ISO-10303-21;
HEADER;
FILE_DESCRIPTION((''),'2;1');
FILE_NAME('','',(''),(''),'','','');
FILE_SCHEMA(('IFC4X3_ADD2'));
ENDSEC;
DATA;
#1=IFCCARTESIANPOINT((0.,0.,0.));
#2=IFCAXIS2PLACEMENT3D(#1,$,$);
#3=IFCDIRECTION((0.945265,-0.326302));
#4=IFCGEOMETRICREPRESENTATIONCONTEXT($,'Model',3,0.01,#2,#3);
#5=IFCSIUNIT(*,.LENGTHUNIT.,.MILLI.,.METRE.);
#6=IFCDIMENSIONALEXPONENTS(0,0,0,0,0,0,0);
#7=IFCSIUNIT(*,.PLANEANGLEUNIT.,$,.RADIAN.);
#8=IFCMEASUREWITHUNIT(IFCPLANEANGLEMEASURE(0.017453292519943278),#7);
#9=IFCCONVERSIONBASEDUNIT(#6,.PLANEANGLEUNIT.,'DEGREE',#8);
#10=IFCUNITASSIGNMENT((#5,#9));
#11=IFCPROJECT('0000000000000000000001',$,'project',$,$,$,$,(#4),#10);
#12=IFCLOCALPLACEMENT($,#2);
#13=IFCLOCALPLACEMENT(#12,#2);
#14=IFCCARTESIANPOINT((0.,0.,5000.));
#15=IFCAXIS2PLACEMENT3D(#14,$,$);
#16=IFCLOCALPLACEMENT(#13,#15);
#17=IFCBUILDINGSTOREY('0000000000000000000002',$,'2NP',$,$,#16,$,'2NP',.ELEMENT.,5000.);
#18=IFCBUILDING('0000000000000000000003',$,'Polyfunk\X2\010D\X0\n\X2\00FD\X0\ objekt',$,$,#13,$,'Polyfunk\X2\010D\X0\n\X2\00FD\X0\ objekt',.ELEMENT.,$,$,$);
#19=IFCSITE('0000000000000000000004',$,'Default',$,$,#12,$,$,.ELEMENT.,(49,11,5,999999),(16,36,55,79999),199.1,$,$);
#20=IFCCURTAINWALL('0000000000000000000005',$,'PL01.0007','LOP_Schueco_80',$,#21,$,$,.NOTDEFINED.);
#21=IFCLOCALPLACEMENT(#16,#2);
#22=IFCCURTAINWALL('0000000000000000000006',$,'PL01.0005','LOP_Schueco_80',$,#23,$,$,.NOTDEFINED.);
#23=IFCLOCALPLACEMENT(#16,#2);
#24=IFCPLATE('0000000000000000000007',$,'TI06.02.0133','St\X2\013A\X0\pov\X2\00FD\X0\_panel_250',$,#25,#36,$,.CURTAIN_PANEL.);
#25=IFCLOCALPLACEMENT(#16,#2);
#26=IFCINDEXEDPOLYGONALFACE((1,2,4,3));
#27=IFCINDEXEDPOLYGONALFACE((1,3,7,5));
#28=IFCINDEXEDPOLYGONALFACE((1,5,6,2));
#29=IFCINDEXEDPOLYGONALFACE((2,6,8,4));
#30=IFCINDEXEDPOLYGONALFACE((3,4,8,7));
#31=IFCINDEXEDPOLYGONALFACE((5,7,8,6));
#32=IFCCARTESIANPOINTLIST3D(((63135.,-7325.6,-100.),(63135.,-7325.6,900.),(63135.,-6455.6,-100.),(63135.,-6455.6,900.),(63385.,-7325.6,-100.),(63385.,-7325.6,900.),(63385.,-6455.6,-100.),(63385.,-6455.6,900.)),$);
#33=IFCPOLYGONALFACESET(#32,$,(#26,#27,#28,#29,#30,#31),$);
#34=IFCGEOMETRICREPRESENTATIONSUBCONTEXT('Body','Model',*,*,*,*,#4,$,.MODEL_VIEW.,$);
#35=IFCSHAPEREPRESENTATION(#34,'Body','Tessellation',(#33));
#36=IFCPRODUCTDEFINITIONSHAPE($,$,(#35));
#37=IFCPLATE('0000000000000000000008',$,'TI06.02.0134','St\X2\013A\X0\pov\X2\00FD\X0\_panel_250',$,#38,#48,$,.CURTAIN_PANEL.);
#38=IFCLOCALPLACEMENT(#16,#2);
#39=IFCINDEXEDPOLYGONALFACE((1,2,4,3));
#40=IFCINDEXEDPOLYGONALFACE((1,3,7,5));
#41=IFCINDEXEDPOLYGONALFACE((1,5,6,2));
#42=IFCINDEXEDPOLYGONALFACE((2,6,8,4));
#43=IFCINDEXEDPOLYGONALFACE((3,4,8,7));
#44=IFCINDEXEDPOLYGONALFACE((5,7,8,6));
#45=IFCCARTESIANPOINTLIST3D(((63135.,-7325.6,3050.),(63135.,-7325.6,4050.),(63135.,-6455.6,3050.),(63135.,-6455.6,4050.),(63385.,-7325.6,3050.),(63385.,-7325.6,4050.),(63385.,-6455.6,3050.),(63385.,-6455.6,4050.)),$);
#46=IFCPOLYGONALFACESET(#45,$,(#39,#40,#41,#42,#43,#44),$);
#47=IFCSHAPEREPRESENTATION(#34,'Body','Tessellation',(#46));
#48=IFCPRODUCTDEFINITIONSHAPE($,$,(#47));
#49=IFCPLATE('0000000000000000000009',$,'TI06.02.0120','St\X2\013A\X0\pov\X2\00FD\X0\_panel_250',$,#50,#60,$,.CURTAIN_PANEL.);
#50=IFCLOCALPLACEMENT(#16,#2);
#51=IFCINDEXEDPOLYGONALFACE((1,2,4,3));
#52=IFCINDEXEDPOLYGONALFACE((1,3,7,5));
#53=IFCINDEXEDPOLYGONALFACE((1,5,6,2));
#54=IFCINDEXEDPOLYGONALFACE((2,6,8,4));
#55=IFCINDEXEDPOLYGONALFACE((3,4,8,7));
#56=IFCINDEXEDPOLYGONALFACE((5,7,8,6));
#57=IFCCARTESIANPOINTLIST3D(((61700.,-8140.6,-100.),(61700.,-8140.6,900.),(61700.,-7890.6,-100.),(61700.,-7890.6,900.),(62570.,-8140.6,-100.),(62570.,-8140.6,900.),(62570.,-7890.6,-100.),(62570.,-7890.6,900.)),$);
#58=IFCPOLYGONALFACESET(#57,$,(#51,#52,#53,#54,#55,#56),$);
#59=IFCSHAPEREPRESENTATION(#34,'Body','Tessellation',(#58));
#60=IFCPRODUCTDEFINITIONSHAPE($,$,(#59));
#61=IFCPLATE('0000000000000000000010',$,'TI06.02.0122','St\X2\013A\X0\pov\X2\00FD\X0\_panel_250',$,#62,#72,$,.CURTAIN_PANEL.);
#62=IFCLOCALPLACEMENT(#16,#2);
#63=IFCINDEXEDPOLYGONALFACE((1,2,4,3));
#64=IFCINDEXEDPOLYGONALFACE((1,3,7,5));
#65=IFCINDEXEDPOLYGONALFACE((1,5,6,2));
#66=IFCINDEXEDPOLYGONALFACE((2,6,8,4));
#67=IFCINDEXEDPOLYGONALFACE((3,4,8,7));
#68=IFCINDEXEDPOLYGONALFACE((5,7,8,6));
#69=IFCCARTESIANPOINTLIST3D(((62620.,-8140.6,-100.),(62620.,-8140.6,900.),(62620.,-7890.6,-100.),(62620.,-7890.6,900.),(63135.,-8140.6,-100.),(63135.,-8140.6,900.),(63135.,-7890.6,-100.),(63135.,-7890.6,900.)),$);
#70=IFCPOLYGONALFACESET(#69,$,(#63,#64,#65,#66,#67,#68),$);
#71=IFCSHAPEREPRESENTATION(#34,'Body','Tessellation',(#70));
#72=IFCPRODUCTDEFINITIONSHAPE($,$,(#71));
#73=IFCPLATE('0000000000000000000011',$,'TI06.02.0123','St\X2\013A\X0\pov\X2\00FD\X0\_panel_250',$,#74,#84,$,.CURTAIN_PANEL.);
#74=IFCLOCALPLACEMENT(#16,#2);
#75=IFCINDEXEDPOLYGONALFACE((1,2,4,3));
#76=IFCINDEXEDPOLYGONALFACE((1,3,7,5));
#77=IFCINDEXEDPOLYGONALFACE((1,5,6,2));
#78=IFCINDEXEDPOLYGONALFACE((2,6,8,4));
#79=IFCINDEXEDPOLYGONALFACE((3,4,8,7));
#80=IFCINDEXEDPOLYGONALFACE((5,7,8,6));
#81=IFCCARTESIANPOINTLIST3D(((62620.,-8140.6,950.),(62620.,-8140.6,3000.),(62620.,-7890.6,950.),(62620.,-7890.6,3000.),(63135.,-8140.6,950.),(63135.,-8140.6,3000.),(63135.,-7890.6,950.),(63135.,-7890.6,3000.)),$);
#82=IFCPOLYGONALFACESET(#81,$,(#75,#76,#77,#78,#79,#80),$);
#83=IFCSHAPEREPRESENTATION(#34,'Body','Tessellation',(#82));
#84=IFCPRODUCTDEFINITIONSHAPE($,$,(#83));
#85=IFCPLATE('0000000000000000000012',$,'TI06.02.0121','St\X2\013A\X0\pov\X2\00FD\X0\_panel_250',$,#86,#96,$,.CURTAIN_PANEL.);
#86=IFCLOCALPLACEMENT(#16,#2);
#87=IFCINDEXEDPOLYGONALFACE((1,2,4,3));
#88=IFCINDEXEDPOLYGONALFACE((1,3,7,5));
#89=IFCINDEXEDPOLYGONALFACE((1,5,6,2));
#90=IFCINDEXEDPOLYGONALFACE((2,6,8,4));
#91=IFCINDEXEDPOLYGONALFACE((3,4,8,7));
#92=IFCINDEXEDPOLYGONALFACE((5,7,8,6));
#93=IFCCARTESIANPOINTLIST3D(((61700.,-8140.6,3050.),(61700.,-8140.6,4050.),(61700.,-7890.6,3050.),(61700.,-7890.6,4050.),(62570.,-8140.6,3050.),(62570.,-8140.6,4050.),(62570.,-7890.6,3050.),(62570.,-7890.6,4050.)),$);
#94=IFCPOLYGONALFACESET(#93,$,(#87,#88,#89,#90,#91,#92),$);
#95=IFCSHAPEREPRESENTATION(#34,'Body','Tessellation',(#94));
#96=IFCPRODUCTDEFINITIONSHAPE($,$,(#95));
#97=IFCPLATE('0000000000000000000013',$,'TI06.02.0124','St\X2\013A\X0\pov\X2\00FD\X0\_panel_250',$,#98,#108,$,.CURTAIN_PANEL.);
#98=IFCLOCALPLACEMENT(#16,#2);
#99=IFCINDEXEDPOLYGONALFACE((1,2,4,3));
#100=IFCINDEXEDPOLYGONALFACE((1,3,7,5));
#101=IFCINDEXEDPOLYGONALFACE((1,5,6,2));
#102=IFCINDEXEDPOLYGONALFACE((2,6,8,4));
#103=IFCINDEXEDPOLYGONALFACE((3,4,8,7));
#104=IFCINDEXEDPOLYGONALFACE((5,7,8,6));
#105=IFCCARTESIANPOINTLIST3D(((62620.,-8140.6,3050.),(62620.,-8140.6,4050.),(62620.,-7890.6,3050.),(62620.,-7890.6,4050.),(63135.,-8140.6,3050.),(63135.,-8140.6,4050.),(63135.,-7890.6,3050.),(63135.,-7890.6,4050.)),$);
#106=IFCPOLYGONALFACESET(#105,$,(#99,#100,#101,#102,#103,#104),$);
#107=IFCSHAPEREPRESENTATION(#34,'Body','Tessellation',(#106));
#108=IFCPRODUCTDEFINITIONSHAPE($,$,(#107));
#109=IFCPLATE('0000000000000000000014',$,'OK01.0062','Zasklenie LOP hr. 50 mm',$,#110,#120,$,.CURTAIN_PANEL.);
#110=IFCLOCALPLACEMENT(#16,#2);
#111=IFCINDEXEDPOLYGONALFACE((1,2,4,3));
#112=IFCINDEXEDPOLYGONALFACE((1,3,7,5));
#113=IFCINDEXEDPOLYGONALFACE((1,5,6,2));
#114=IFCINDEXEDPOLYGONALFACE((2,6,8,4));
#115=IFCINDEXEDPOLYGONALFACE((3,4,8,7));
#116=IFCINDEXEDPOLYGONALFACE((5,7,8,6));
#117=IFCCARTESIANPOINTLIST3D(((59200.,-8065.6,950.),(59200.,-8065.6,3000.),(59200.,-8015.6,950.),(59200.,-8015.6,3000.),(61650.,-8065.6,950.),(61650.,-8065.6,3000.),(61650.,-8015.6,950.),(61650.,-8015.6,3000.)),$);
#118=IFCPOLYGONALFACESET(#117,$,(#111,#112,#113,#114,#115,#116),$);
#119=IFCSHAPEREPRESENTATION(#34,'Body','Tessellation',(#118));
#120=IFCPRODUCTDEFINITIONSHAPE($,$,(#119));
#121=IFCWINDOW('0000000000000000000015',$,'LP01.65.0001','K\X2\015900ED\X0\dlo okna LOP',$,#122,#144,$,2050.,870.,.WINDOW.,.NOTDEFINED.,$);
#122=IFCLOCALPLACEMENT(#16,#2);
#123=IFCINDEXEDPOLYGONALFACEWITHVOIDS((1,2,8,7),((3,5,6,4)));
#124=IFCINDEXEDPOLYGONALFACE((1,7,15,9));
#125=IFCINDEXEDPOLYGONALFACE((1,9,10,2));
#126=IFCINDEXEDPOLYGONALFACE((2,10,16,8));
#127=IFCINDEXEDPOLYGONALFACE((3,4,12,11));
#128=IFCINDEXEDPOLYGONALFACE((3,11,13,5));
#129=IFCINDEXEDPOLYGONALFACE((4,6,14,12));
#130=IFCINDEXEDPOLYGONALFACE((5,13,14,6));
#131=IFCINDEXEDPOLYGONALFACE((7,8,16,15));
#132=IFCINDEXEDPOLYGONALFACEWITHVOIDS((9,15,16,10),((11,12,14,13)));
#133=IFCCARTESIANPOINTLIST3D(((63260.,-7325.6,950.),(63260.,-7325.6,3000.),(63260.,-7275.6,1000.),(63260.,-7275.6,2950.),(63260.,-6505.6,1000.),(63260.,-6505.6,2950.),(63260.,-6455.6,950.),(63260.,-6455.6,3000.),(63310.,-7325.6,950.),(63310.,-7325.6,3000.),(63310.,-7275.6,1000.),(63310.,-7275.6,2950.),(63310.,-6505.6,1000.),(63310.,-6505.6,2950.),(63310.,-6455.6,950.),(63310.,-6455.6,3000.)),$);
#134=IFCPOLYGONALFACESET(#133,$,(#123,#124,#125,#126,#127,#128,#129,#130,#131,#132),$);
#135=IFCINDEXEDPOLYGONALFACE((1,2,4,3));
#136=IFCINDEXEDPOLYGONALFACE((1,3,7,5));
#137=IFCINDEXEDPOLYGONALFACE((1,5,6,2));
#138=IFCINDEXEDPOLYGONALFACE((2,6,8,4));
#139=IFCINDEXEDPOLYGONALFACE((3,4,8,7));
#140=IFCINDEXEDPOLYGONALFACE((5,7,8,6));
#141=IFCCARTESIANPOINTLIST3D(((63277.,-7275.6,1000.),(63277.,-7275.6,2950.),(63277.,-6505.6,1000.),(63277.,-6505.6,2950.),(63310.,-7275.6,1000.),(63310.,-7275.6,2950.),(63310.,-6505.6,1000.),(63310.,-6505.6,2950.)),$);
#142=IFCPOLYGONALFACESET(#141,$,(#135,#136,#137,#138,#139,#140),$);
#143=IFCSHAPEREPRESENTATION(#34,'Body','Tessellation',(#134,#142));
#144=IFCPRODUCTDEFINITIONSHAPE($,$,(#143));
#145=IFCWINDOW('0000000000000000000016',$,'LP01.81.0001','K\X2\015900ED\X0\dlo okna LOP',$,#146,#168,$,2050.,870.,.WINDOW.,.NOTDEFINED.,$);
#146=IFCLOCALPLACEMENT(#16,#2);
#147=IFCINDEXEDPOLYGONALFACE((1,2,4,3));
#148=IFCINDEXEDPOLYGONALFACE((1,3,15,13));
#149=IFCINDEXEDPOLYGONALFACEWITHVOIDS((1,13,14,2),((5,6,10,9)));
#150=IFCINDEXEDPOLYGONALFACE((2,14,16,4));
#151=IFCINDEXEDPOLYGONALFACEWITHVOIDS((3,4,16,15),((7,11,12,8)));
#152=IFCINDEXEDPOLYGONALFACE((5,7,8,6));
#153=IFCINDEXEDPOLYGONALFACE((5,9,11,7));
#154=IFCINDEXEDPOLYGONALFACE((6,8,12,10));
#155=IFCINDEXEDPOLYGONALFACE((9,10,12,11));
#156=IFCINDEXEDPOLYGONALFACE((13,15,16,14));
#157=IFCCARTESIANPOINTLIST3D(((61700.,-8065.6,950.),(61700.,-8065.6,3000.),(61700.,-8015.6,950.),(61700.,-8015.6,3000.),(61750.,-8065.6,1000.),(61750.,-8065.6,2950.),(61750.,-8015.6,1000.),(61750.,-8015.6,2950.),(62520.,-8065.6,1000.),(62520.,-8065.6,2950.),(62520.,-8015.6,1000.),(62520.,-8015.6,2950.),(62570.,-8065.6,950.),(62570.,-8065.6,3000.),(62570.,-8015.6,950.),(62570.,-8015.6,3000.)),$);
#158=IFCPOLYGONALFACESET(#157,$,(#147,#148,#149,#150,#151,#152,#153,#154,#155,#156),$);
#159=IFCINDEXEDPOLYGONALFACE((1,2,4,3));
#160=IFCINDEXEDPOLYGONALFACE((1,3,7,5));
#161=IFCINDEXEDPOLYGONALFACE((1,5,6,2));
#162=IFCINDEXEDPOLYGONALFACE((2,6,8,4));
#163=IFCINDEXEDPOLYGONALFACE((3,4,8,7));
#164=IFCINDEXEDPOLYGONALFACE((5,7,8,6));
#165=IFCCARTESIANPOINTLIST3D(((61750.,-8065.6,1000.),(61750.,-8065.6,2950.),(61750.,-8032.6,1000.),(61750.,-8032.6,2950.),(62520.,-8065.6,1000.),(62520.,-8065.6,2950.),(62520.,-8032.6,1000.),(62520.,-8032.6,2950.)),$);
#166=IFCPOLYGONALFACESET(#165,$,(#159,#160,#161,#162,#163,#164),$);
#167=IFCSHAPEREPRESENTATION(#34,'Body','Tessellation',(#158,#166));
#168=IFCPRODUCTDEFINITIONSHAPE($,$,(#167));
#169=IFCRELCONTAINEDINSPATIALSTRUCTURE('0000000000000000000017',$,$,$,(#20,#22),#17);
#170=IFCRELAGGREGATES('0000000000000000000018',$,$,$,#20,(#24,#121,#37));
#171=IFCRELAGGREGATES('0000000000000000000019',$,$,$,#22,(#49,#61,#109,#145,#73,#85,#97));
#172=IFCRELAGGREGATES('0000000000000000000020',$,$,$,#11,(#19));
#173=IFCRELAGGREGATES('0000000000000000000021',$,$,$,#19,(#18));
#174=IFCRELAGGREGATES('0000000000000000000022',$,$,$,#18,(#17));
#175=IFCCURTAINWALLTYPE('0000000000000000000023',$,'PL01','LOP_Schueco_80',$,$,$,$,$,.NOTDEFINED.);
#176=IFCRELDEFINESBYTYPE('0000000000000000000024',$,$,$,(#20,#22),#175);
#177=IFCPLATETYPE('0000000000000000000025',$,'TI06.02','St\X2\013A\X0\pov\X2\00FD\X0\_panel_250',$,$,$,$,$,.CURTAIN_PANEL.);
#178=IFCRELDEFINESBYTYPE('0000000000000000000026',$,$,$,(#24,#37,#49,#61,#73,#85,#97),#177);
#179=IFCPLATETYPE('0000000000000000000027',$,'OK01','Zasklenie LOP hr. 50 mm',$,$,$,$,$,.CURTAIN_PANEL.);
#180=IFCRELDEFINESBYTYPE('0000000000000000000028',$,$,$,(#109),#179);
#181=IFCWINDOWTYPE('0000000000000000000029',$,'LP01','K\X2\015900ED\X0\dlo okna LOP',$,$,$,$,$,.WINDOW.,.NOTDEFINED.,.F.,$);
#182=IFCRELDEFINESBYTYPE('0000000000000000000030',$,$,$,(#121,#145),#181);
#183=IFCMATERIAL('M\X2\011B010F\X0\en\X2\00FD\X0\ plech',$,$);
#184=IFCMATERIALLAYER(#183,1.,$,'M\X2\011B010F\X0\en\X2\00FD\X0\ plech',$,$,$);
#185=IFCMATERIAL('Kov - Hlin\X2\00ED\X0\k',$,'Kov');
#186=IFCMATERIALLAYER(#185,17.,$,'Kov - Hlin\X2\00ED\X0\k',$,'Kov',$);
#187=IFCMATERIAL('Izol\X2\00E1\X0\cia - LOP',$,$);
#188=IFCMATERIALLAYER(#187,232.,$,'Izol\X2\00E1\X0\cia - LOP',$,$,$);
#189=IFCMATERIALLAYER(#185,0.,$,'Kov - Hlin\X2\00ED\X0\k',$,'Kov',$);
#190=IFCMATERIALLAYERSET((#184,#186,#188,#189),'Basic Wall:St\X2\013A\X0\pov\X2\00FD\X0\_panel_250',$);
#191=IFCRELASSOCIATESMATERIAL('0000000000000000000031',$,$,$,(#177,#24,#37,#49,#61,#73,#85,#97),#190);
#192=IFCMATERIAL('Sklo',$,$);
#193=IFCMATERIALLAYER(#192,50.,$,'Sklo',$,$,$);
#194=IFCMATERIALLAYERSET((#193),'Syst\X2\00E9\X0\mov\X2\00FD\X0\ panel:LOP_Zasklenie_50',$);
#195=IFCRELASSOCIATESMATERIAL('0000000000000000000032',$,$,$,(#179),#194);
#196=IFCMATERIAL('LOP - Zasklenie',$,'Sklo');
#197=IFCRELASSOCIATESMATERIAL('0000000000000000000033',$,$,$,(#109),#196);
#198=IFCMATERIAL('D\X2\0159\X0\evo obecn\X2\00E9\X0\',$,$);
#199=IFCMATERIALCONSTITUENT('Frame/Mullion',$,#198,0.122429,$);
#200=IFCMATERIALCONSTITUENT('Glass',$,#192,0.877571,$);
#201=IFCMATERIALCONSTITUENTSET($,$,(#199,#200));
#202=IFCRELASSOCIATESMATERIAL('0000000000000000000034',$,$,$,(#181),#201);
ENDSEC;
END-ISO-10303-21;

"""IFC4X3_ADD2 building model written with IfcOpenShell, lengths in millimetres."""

from ifc_helpers import new_model, entity, si_unit, converted_unit, direction, frame, frame_2d, origin, origin_2d_with_axis, place, context, subcontext, project, spatial, polyline, rectangle, outline, extrude, source, transform, mapped, material, layer, layer_set, layer_usage, constituent, constituent_set, type_object, type_shapes, element, aggregate, save


model = new_model("IFC4X3_ADD2")

# Units and contexts
model_context = context("Model", 3, precision=0.01, world=origin(), true_north=direction((0.945265, -0.326302)))
body_context = subcontext(model_context, "Body", "Model", "MODEL_VIEW")
ifc_project = project(units=[si_unit("LENGTHUNIT", "METRE", prefix="MILLI"), converted_unit("PLANEANGLEUNIT", "DEGREE", entity("IfcPlaneAngleMeasure", 0.017453292519943278), si_unit("PLANEANGLEUNIT", "RADIAN"), dimensions=[0, 0, 0, 0, 0, 0, 0])], contexts=[model_context])

# Site, building, storey
site_placement = place(None, origin())
site = spatial("IfcSite", under=ifc_project, at=site_placement, Name="Default", CompositionType="ELEMENT", RefLatitude=(49, 11, 5, 999999), RefLongitude=(16, 36, 55, 79999), RefElevation=199.1)
building_placement = place(site_placement, origin())
building = spatial("IfcBuilding", under=site, at=building_placement, Name="Polyfunkčný objekt", LongName="Polyfunkčný objekt", CompositionType="ELEMENT")
storey_placement = place(building_placement, frame((0.0, 0.0, 5000.0)))
storey = spatial("IfcBuildingStorey", under=building, at=storey_placement, Name="2NP", LongName="2NP", CompositionType="ELEMENT", Elevation=5000.0)

# Curtain walls
curtain_wall_type = type_object("IfcCurtainWallType", Name="PL01", Description="LOP_Schueco_80", PredefinedType="NOTDEFINED")
curtain_wall_1_placement = place(storey_placement, frame((0.0, 0.0, -5000.0)))
curtain_wall_1 = element("IfcCurtainWall", 1, at=curtain_wall_1_placement, inside=storey, type_object=curtain_wall_type, Name="PL01.0007", Description="LOP_Schueco_80", PredefinedType="NOTDEFINED")
curtain_wall_2_placement = place(storey_placement, frame((0.0, 0.0, -5000.0)))
curtain_wall_2 = element("IfcCurtainWall", 2, at=curtain_wall_2_placement, inside=storey, type_object=curtain_wall_type, Name="PL01.0005", Description="LOP_Schueco_80", PredefinedType="NOTDEFINED")

# Plates
ifc_material_1 = material(Name="Měďený plech")
ifc_layer_1 = layer(ifc_material_1, 1.0, Name="Měďený plech")
ifc_material_2 = material(Name="Kov - Hliník", Category="Kov")
ifc_layer_2 = layer(ifc_material_2, 17.0, Name="Kov - Hliník", Category="Kov")
ifc_material_3 = material(Name="Izolácia - LOP")
ifc_layer_3 = layer(ifc_material_3, 232.0, Name="Izolácia - LOP")
ifc_layer_4 = layer(ifc_material_2, 0.0, Name="Kov - Hliník", Category="Kov")
ifc_layer_set_1 = layer_set([ifc_layer_1, ifc_layer_2, ifc_layer_3, ifc_layer_4], Name="Basic Wall:Stĺpový_panel_250")
ifc_layer_usage_1 = layer_usage(ifc_layer_set_1, "AXIS2", "NEGATIVE", 125.0)
plate_type_1 = type_object("IfcPlateType", Name="TI06.02", Description="Stĺpový_panel_250", PredefinedType="CURTAIN_PANEL", material=ifc_layer_set_1)
plate_1_placement = place(storey_placement, frame((63260.0, -6455.6, -100.0), z_axis=(0.0, 0.0, 1.0), x_axis=(0.0, -1.0, 0.0)))
plate_1 = element("IfcPlate", 3, at=plate_1_placement, type_object=plate_type_1, material=ifc_layer_usage_1, Name="TI06.02.0133", Description="Stĺpový_panel_250", PredefinedType="CURTAIN_PANEL", context=body_context, shape_type="SweptSolid", body=[
    extrude(rectangle(XDim=250.0, YDim=870.0, at=frame_2d((0.0, 0.0), x_axis=(1.0, 0.0))), frame((435.0, 0.0, 0.0), z_axis=(0.0, 0.0, 1.0), x_axis=(0.0, 1.0, 0.0)), (0.0, 0.0, 1.0), 1000.0),
])
ifc_layer_usage_2 = layer_usage(ifc_layer_set_1, "AXIS2", "NEGATIVE", 125.0)
plate_2_placement = place(storey_placement, frame((63260.0, -6455.6, 3050.0), z_axis=(0.0, 0.0, 1.0), x_axis=(0.0, -1.0, 0.0)))
plate_2 = element("IfcPlate", 4, at=plate_2_placement, type_object=plate_type_1, material=ifc_layer_usage_2, Name="TI06.02.0134", Description="Stĺpový_panel_250", PredefinedType="CURTAIN_PANEL", context=body_context, shape_type="SweptSolid", body=[
    extrude(rectangle(XDim=250.0, YDim=870.0, at=frame_2d((0.0, 0.0), x_axis=(1.0, 0.0))), frame((435.0, 0.0, 0.0), z_axis=(0.0, 0.0, 1.0), x_axis=(0.0, 1.0, 0.0)), (0.0, 0.0, 1.0), 1000.0),
])
ifc_layer_usage_3 = layer_usage(ifc_layer_set_1, "AXIS2", "POSITIVE", -125.0)
plate_3_placement = place(storey_placement, frame((61700.0, -8015.6, -100.0)))
plate_3 = element("IfcPlate", 5, at=plate_3_placement, type_object=plate_type_1, material=ifc_layer_usage_3, Name="TI06.02.0120", Description="Stĺpový_panel_250", PredefinedType="CURTAIN_PANEL", context=body_context, shape_type="SweptSolid", body=[
    extrude(rectangle(XDim=250.0, YDim=870.0, at=frame_2d((0.0, 0.0), x_axis=(1.0, 0.0))), frame((435.0, 0.0, 0.0), z_axis=(0.0, 0.0, 1.0), x_axis=(0.0, 1.0, 0.0)), (0.0, 0.0, 1.0), 1000.0),
])
ifc_layer_usage_4 = layer_usage(ifc_layer_set_1, "AXIS2", "POSITIVE", -125.0)
plate_4_placement = place(storey_placement, frame((62620.0, -8015.6, -100.0)))
plate_4 = element("IfcPlate", 6, at=plate_4_placement, type_object=plate_type_1, material=ifc_layer_usage_4, Name="TI06.02.0122", Description="Stĺpový_panel_250", PredefinedType="CURTAIN_PANEL", context=body_context, shape_type="SweptSolid", body=[
    extrude(rectangle(XDim=250.0, YDim=515.0, at=frame_2d((0.0, 0.0), x_axis=(1.0, 0.0))), frame((257.5, 0.0, 0.0), z_axis=(0.0, 0.0, 1.0), x_axis=(0.0, 1.0, 0.0)), (0.0, 0.0, 1.0), 1000.0),
])
ifc_layer_usage_5 = layer_usage(ifc_layer_set_1, "AXIS2", "POSITIVE", -125.0)
plate_5_placement = place(storey_placement, frame((62620.0, -8015.6, 950.0)))
plate_5 = element("IfcPlate", 7, at=plate_5_placement, type_object=plate_type_1, material=ifc_layer_usage_5, Name="TI06.02.0123", Description="Stĺpový_panel_250", PredefinedType="CURTAIN_PANEL", context=body_context, shape_type="SweptSolid", body=[
    extrude(rectangle(XDim=250.0, YDim=515.0, at=frame_2d((0.0, 0.0), x_axis=(1.0, 0.0))), frame((257.5, 0.0, 0.0), z_axis=(0.0, 0.0, 1.0), x_axis=(0.0, 1.0, 0.0)), (0.0, 0.0, 1.0), 2050.0),
])
ifc_layer_usage_6 = layer_usage(ifc_layer_set_1, "AXIS2", "POSITIVE", -125.0)
plate_6_placement = place(storey_placement, frame((61700.0, -8015.6, 3050.0)))
plate_6 = element("IfcPlate", 8, at=plate_6_placement, type_object=plate_type_1, material=ifc_layer_usage_6, Name="TI06.02.0121", Description="Stĺpový_panel_250", PredefinedType="CURTAIN_PANEL", context=body_context, shape_type="SweptSolid", body=[
    extrude(rectangle(XDim=250.0, YDim=870.0, at=frame_2d((0.0, 0.0), x_axis=(1.0, 0.0))), frame((435.0, 0.0, 0.0), z_axis=(0.0, 0.0, 1.0), x_axis=(0.0, 1.0, 0.0)), (0.0, 0.0, 1.0), 1000.0),
])
ifc_layer_usage_7 = layer_usage(ifc_layer_set_1, "AXIS2", "POSITIVE", -125.0)
plate_7_placement = place(storey_placement, frame((62620.0, -8015.6, 3050.0)))
plate_7 = element("IfcPlate", 9, at=plate_7_placement, type_object=plate_type_1, material=ifc_layer_usage_7, Name="TI06.02.0124", Description="Stĺpový_panel_250", PredefinedType="CURTAIN_PANEL", context=body_context, shape_type="SweptSolid", body=[
    extrude(rectangle(XDim=250.0, YDim=515.0, at=frame_2d((0.0, 0.0), x_axis=(1.0, 0.0))), frame((257.5, 0.0, 0.0), z_axis=(0.0, 0.0, 1.0), x_axis=(0.0, 1.0, 0.0)), (0.0, 0.0, 1.0), 1000.0),
])
ifc_material_4 = material(Name="LOP - Zasklenie", Category="Sklo")
ifc_material_5 = material(Name="Sklo")
ifc_layer_5 = layer(ifc_material_5, 50.0, Name="Sklo")
ifc_layer_set_2 = layer_set([ifc_layer_5], Name="Systémový panel:LOP_Zasklenie_50")
plate_type_2 = type_object("IfcPlateType", Name="OK01", Description="Zasklenie LOP hr. 50 mm", PredefinedType="CURTAIN_PANEL", material=ifc_layer_set_2)
shared_shape_1 = source(origin(), body_context, "Body", "SweptSolid", [
    extrude(rectangle(XDim=50.0, YDim=2450.0, at=origin_2d_with_axis()), frame((0.0, -25.0, 0.0), z_axis=(0.0, 0.0, 1.0), x_axis=(0.0, 1.0, 0.0)), (0.0, 0.0, 1.0), 2050.0),
])
type_shapes(plate_type_2, [shared_shape_1])
plate_8_placement = place(curtain_wall_2_placement, frame((60425.0, -8015.6, 5950.0)))
plate_8 = element("IfcPlate", 10, at=plate_8_placement, type_object=plate_type_2, material=ifc_material_4, Name="OK01.0062", Description="Zasklenie LOP hr. 50 mm", PredefinedType="CURTAIN_PANEL", context=body_context, shape_type="MappedRepresentation", body=[
    mapped(shared_shape_1, transform((0.0, 0.0, 0.0), scale=1.0)),
])

# Windows
ifc_material_6 = material(Name="Dřevo obecné")
ifc_constituent_1 = constituent(ifc_material_6, Name="Frame/Mullion", fraction=0.122429)
ifc_constituent_2 = constituent(ifc_material_5, Name="Glass", fraction=0.877571)
ifc_constituent_set = constituent_set(constituents=[ifc_constituent_1, ifc_constituent_2])
window_type = type_object("IfcWindowType", Name="LP01", Description="Křídlo okna LOP", ParameterTakesPrecedence=False, PartitioningType="NOTDEFINED", PredefinedType="WINDOW", material=ifc_constituent_set)
shared_shape_2 = source(origin(), body_context, "Body", "SweptSolid", [
    extrude(outline(polyline([(-1025.0, -435.0), (1025.0, -435.0), (1025.0, 435.0), (-1025.0, 435.0), (-1025.0, -435.0)]), holes=[polyline([(-975.0, -385.0), (-975.0, 385.0), (975.0, 385.0), (975.0, -385.0), (-975.0, -385.0)])]), frame((0.0, 0.0, 1025.0), z_axis=(0.0, 1.0, 0.0), x_axis=(0.0, 0.0, -1.0)), (0.0, 0.0, 1.0), 50.0),
    extrude(rectangle(XDim=33.0, YDim=770.0, at=origin_2d_with_axis()), frame((0.0, 33.5, 50.0), z_axis=(0.0, 0.0, 1.0), x_axis=(0.0, -1.0, 0.0)), (0.0, 0.0, 1.0), 1950.0),
])
window_1_placement = place(curtain_wall_1_placement, frame((63260.0, -6890.6, 5950.0), z_axis=(0.0, 0.0, 1.0), x_axis=(0.0, -1.0, 0.0)))
window_1 = element("IfcWindow", 11, at=window_1_placement, type_object=window_type, Name="LP01.65.0001", Description="Křídlo okna LOP", OverallHeight=2050.0, OverallWidth=870.0, PartitioningType="NOTDEFINED", PredefinedType="WINDOW", context=body_context, shape_type="MappedRepresentation", body=[
    mapped(shared_shape_2, transform((0.0, 0.0, 0.0), scale=1.0)),
])
aggregate(curtain_wall_1, [plate_1, window_1, plate_2])
shared_shape_3 = source(origin(), body_context, "Body", "SweptSolid", [
    extrude(outline(polyline([(-1025.0, -435.0), (1025.0, -435.0), (1025.0, 435.0), (-1025.0, 435.0), (-1025.0, -435.0)]), holes=[polyline([(-975.0, -385.0), (-975.0, 385.0), (975.0, 385.0), (975.0, -385.0), (-975.0, -385.0)])]), frame((0.0, 50.0, 1025.0), z_axis=(0.0, -1.0, 0.0), x_axis=(0.0, 0.0, -1.0)), (0.0, 0.0, 1.0), 50.0),
    extrude(rectangle(XDim=770.0, YDim=33.0, at=frame_2d((0.0, 0.0), x_axis=(1.0, 0.0))), frame((0.0, 33.5, 50.0), z_axis=(0.0, 0.0, 1.0), x_axis=(-1.0, 0.0, 0.0)), (0.0, 0.0, 1.0), 1950.0),
])
type_shapes(window_type, [shared_shape_2, shared_shape_3])
window_2_placement = place(curtain_wall_2_placement, frame((62135.0, -8015.6, 5950.0), z_axis=(0.0, 0.0, 1.0), x_axis=(-1.0, 0.0, 0.0)))
window_2 = element("IfcWindow", 12, at=window_2_placement, type_object=window_type, Name="LP01.81.0001", Description="Křídlo okna LOP", OverallHeight=2050.0, OverallWidth=870.0, PartitioningType="NOTDEFINED", PredefinedType="WINDOW", context=body_context, shape_type="MappedRepresentation", body=[
    mapped(shared_shape_3, transform((0.0, 0.0, 0.0), scale=1.0)),
])
aggregate(curtain_wall_2, [plate_3, plate_4, plate_8, window_2, plate_5, plate_6, plate_7])

save(model, "model.ifc")
